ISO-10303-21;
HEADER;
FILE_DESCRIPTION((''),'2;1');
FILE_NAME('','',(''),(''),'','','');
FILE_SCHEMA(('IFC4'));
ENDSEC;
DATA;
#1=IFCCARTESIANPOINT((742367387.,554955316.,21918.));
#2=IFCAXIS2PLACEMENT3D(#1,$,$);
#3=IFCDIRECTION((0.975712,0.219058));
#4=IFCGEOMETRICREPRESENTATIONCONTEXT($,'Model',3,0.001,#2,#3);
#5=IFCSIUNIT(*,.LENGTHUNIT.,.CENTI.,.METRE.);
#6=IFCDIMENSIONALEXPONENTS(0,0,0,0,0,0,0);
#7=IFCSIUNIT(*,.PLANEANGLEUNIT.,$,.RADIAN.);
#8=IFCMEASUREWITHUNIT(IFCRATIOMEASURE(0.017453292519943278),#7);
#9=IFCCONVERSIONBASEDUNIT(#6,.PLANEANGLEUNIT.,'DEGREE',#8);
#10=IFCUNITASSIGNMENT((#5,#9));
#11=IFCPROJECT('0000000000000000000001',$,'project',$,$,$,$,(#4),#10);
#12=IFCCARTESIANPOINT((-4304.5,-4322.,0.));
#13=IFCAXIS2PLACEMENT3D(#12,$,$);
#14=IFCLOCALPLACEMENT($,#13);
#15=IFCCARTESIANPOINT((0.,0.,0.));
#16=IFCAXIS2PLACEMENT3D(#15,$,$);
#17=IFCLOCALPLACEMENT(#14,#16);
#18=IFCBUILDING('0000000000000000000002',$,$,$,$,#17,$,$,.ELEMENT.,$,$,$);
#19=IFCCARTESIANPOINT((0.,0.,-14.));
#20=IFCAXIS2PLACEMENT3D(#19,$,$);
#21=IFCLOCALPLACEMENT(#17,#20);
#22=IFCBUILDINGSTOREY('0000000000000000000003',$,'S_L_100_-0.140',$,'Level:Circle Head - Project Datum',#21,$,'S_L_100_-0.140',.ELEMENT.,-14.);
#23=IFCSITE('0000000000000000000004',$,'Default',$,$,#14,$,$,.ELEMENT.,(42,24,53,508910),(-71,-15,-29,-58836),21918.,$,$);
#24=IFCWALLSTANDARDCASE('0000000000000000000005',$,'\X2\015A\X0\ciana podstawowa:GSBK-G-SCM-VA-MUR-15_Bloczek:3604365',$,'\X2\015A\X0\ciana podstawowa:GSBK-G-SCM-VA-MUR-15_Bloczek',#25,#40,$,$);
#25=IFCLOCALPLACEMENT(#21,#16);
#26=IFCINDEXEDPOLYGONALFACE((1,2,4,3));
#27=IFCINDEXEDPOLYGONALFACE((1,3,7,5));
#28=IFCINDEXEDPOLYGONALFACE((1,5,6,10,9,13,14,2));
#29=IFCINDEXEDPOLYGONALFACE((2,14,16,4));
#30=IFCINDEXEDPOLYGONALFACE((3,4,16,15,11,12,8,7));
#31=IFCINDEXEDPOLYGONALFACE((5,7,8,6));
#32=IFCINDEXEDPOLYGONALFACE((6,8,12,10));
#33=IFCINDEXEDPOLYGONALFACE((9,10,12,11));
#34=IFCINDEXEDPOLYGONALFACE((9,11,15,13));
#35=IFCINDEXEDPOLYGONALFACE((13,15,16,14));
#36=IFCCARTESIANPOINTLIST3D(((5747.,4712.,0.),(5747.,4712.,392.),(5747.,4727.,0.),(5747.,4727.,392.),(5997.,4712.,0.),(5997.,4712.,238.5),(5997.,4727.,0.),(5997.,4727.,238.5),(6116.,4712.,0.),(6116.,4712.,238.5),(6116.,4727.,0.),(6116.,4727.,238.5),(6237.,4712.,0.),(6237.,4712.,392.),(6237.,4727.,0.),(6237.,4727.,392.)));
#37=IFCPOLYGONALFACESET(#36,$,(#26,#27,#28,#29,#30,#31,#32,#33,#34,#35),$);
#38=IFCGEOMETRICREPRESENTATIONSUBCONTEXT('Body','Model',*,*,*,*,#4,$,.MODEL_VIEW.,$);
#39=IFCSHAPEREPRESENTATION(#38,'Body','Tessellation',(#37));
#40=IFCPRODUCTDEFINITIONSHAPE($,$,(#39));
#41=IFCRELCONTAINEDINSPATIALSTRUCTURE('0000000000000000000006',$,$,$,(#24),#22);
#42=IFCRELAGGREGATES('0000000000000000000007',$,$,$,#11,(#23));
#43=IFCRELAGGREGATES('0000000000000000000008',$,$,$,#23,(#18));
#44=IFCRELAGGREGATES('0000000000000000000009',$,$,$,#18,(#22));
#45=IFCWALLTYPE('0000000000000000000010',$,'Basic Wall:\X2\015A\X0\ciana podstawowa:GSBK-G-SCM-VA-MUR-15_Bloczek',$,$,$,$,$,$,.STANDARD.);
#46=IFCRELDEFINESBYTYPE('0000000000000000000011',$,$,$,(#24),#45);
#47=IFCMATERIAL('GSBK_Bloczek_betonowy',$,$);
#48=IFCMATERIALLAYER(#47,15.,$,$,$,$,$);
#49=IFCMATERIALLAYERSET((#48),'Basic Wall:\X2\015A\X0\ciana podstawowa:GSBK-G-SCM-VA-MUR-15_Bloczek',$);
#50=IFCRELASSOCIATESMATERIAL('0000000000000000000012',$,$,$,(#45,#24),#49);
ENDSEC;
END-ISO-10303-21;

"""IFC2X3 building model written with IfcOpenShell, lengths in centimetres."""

from ifc_helpers import new_model, entity, si_unit, converted_unit, direction, frame, frame_2d, origin, place, context, subcontext, project, spatial, rectangle, extrude, material, layer, layer_set, layer_usage, type_object, element, save


model = new_model("IFC2X3")

# Units and contexts
model_context = context("Model", 3, precision=0.001, world=frame((742367387.0, 554955316.0, 21918.0)), true_north=direction((0.975712, 0.219058)))
body_context = subcontext(model_context, "Body", "Model", "MODEL_VIEW")
ifc_project = project(units=[si_unit("LENGTHUNIT", "METRE", prefix="CENTI"), converted_unit("PLANEANGLEUNIT", "DEGREE", entity("IfcRatioMeasure", 0.017453292519943278), si_unit("PLANEANGLEUNIT", "RADIAN"), dimensions=[0, 0, 0, 0, 0, 0, 0])], contexts=[model_context])

# Site, building, storey
site_placement = place(None, frame((-4304.5, -4322.0, 0.0)))
site = spatial("IfcSite", under=ifc_project, at=site_placement, Name="Default", CompositionType="ELEMENT", RefLatitude=(42, 24, 53, 508910), RefLongitude=(-71, -15, -29, -58836), RefElevation=21918.0)
building_placement = place(site_placement, origin())
building = spatial("IfcBuilding", under=site, at=building_placement, CompositionType="ELEMENT")
storey_placement = place(building_placement, frame((0.0, 0.0, -14.0)))
storey = spatial("IfcBuildingStorey", under=building, at=storey_placement, Name="S_L_100_-0.140", ObjectType="Level:Circle Head - Project Datum", LongName="S_L_100_-0.140", CompositionType="ELEMENT", Elevation=-14.0)

# Wall, opening
ifc_material_1 = material(Name="GSBK_Bloczek_betonowy")
ifc_layer_1 = layer(ifc_material_1, 15.0)
ifc_layer_set_1 = layer_set([ifc_layer_1], Name="Basic Wall:Ściana podstawowa:GSBK-G-SCM-VA-MUR-15_Bloczek")
ifc_layer_usage_1 = layer_usage(ifc_layer_set_1, "AXIS2", "NEGATIVE", 7.5)
wall_type_1 = type_object("IfcWallType", Name="Basic Wall:Ściana podstawowa:GSBK-G-SCM-VA-MUR-15_Bloczek", PredefinedType="STANDARD", material=ifc_layer_set_1)
wall_1_placement = place(storey_placement, frame((5747.0, 4719.5, 0.0)))
wall_1 = element("IfcWallStandardCase", 1, at=wall_1_placement, inside=storey, type_object=wall_type_1, material=ifc_layer_usage_1, Name="Ściana podstawowa:GSBK-G-SCM-VA-MUR-15_Bloczek:3604365", ObjectType="Ściana podstawowa:GSBK-G-SCM-VA-MUR-15_Bloczek", context=body_context, shape_type="SweptSolid", body=[
    extrude(rectangle(XDim=490.0, YDim=15.0, at=frame_2d((245.0, 0.0), x_axis=(1.0, 0.0))), origin(), (0.0, 0.0, 1.0), 392.0),
])
opening_1_placement = place(wall_1_placement, frame((250.0, -7.5, 0.0)))
element("IfcOpeningElement", 2, at=opening_1_placement, cuts=wall_1, ObjectType="Opening", context=body_context, shape_type="SweptSolid", body=[
    extrude(rectangle(XDim=238.5, YDim=119.0, at=frame_2d((0.0, 0.0), x_axis=(1.0, 0.0))), frame((59.5, 0.0, 119.25), z_axis=(0.0, 1.0, 0.0), x_axis=(0.0, 0.0, -1.0)), (0.0, 0.0, 1.0), 15.0),
])

save(model, "model.ifc")
